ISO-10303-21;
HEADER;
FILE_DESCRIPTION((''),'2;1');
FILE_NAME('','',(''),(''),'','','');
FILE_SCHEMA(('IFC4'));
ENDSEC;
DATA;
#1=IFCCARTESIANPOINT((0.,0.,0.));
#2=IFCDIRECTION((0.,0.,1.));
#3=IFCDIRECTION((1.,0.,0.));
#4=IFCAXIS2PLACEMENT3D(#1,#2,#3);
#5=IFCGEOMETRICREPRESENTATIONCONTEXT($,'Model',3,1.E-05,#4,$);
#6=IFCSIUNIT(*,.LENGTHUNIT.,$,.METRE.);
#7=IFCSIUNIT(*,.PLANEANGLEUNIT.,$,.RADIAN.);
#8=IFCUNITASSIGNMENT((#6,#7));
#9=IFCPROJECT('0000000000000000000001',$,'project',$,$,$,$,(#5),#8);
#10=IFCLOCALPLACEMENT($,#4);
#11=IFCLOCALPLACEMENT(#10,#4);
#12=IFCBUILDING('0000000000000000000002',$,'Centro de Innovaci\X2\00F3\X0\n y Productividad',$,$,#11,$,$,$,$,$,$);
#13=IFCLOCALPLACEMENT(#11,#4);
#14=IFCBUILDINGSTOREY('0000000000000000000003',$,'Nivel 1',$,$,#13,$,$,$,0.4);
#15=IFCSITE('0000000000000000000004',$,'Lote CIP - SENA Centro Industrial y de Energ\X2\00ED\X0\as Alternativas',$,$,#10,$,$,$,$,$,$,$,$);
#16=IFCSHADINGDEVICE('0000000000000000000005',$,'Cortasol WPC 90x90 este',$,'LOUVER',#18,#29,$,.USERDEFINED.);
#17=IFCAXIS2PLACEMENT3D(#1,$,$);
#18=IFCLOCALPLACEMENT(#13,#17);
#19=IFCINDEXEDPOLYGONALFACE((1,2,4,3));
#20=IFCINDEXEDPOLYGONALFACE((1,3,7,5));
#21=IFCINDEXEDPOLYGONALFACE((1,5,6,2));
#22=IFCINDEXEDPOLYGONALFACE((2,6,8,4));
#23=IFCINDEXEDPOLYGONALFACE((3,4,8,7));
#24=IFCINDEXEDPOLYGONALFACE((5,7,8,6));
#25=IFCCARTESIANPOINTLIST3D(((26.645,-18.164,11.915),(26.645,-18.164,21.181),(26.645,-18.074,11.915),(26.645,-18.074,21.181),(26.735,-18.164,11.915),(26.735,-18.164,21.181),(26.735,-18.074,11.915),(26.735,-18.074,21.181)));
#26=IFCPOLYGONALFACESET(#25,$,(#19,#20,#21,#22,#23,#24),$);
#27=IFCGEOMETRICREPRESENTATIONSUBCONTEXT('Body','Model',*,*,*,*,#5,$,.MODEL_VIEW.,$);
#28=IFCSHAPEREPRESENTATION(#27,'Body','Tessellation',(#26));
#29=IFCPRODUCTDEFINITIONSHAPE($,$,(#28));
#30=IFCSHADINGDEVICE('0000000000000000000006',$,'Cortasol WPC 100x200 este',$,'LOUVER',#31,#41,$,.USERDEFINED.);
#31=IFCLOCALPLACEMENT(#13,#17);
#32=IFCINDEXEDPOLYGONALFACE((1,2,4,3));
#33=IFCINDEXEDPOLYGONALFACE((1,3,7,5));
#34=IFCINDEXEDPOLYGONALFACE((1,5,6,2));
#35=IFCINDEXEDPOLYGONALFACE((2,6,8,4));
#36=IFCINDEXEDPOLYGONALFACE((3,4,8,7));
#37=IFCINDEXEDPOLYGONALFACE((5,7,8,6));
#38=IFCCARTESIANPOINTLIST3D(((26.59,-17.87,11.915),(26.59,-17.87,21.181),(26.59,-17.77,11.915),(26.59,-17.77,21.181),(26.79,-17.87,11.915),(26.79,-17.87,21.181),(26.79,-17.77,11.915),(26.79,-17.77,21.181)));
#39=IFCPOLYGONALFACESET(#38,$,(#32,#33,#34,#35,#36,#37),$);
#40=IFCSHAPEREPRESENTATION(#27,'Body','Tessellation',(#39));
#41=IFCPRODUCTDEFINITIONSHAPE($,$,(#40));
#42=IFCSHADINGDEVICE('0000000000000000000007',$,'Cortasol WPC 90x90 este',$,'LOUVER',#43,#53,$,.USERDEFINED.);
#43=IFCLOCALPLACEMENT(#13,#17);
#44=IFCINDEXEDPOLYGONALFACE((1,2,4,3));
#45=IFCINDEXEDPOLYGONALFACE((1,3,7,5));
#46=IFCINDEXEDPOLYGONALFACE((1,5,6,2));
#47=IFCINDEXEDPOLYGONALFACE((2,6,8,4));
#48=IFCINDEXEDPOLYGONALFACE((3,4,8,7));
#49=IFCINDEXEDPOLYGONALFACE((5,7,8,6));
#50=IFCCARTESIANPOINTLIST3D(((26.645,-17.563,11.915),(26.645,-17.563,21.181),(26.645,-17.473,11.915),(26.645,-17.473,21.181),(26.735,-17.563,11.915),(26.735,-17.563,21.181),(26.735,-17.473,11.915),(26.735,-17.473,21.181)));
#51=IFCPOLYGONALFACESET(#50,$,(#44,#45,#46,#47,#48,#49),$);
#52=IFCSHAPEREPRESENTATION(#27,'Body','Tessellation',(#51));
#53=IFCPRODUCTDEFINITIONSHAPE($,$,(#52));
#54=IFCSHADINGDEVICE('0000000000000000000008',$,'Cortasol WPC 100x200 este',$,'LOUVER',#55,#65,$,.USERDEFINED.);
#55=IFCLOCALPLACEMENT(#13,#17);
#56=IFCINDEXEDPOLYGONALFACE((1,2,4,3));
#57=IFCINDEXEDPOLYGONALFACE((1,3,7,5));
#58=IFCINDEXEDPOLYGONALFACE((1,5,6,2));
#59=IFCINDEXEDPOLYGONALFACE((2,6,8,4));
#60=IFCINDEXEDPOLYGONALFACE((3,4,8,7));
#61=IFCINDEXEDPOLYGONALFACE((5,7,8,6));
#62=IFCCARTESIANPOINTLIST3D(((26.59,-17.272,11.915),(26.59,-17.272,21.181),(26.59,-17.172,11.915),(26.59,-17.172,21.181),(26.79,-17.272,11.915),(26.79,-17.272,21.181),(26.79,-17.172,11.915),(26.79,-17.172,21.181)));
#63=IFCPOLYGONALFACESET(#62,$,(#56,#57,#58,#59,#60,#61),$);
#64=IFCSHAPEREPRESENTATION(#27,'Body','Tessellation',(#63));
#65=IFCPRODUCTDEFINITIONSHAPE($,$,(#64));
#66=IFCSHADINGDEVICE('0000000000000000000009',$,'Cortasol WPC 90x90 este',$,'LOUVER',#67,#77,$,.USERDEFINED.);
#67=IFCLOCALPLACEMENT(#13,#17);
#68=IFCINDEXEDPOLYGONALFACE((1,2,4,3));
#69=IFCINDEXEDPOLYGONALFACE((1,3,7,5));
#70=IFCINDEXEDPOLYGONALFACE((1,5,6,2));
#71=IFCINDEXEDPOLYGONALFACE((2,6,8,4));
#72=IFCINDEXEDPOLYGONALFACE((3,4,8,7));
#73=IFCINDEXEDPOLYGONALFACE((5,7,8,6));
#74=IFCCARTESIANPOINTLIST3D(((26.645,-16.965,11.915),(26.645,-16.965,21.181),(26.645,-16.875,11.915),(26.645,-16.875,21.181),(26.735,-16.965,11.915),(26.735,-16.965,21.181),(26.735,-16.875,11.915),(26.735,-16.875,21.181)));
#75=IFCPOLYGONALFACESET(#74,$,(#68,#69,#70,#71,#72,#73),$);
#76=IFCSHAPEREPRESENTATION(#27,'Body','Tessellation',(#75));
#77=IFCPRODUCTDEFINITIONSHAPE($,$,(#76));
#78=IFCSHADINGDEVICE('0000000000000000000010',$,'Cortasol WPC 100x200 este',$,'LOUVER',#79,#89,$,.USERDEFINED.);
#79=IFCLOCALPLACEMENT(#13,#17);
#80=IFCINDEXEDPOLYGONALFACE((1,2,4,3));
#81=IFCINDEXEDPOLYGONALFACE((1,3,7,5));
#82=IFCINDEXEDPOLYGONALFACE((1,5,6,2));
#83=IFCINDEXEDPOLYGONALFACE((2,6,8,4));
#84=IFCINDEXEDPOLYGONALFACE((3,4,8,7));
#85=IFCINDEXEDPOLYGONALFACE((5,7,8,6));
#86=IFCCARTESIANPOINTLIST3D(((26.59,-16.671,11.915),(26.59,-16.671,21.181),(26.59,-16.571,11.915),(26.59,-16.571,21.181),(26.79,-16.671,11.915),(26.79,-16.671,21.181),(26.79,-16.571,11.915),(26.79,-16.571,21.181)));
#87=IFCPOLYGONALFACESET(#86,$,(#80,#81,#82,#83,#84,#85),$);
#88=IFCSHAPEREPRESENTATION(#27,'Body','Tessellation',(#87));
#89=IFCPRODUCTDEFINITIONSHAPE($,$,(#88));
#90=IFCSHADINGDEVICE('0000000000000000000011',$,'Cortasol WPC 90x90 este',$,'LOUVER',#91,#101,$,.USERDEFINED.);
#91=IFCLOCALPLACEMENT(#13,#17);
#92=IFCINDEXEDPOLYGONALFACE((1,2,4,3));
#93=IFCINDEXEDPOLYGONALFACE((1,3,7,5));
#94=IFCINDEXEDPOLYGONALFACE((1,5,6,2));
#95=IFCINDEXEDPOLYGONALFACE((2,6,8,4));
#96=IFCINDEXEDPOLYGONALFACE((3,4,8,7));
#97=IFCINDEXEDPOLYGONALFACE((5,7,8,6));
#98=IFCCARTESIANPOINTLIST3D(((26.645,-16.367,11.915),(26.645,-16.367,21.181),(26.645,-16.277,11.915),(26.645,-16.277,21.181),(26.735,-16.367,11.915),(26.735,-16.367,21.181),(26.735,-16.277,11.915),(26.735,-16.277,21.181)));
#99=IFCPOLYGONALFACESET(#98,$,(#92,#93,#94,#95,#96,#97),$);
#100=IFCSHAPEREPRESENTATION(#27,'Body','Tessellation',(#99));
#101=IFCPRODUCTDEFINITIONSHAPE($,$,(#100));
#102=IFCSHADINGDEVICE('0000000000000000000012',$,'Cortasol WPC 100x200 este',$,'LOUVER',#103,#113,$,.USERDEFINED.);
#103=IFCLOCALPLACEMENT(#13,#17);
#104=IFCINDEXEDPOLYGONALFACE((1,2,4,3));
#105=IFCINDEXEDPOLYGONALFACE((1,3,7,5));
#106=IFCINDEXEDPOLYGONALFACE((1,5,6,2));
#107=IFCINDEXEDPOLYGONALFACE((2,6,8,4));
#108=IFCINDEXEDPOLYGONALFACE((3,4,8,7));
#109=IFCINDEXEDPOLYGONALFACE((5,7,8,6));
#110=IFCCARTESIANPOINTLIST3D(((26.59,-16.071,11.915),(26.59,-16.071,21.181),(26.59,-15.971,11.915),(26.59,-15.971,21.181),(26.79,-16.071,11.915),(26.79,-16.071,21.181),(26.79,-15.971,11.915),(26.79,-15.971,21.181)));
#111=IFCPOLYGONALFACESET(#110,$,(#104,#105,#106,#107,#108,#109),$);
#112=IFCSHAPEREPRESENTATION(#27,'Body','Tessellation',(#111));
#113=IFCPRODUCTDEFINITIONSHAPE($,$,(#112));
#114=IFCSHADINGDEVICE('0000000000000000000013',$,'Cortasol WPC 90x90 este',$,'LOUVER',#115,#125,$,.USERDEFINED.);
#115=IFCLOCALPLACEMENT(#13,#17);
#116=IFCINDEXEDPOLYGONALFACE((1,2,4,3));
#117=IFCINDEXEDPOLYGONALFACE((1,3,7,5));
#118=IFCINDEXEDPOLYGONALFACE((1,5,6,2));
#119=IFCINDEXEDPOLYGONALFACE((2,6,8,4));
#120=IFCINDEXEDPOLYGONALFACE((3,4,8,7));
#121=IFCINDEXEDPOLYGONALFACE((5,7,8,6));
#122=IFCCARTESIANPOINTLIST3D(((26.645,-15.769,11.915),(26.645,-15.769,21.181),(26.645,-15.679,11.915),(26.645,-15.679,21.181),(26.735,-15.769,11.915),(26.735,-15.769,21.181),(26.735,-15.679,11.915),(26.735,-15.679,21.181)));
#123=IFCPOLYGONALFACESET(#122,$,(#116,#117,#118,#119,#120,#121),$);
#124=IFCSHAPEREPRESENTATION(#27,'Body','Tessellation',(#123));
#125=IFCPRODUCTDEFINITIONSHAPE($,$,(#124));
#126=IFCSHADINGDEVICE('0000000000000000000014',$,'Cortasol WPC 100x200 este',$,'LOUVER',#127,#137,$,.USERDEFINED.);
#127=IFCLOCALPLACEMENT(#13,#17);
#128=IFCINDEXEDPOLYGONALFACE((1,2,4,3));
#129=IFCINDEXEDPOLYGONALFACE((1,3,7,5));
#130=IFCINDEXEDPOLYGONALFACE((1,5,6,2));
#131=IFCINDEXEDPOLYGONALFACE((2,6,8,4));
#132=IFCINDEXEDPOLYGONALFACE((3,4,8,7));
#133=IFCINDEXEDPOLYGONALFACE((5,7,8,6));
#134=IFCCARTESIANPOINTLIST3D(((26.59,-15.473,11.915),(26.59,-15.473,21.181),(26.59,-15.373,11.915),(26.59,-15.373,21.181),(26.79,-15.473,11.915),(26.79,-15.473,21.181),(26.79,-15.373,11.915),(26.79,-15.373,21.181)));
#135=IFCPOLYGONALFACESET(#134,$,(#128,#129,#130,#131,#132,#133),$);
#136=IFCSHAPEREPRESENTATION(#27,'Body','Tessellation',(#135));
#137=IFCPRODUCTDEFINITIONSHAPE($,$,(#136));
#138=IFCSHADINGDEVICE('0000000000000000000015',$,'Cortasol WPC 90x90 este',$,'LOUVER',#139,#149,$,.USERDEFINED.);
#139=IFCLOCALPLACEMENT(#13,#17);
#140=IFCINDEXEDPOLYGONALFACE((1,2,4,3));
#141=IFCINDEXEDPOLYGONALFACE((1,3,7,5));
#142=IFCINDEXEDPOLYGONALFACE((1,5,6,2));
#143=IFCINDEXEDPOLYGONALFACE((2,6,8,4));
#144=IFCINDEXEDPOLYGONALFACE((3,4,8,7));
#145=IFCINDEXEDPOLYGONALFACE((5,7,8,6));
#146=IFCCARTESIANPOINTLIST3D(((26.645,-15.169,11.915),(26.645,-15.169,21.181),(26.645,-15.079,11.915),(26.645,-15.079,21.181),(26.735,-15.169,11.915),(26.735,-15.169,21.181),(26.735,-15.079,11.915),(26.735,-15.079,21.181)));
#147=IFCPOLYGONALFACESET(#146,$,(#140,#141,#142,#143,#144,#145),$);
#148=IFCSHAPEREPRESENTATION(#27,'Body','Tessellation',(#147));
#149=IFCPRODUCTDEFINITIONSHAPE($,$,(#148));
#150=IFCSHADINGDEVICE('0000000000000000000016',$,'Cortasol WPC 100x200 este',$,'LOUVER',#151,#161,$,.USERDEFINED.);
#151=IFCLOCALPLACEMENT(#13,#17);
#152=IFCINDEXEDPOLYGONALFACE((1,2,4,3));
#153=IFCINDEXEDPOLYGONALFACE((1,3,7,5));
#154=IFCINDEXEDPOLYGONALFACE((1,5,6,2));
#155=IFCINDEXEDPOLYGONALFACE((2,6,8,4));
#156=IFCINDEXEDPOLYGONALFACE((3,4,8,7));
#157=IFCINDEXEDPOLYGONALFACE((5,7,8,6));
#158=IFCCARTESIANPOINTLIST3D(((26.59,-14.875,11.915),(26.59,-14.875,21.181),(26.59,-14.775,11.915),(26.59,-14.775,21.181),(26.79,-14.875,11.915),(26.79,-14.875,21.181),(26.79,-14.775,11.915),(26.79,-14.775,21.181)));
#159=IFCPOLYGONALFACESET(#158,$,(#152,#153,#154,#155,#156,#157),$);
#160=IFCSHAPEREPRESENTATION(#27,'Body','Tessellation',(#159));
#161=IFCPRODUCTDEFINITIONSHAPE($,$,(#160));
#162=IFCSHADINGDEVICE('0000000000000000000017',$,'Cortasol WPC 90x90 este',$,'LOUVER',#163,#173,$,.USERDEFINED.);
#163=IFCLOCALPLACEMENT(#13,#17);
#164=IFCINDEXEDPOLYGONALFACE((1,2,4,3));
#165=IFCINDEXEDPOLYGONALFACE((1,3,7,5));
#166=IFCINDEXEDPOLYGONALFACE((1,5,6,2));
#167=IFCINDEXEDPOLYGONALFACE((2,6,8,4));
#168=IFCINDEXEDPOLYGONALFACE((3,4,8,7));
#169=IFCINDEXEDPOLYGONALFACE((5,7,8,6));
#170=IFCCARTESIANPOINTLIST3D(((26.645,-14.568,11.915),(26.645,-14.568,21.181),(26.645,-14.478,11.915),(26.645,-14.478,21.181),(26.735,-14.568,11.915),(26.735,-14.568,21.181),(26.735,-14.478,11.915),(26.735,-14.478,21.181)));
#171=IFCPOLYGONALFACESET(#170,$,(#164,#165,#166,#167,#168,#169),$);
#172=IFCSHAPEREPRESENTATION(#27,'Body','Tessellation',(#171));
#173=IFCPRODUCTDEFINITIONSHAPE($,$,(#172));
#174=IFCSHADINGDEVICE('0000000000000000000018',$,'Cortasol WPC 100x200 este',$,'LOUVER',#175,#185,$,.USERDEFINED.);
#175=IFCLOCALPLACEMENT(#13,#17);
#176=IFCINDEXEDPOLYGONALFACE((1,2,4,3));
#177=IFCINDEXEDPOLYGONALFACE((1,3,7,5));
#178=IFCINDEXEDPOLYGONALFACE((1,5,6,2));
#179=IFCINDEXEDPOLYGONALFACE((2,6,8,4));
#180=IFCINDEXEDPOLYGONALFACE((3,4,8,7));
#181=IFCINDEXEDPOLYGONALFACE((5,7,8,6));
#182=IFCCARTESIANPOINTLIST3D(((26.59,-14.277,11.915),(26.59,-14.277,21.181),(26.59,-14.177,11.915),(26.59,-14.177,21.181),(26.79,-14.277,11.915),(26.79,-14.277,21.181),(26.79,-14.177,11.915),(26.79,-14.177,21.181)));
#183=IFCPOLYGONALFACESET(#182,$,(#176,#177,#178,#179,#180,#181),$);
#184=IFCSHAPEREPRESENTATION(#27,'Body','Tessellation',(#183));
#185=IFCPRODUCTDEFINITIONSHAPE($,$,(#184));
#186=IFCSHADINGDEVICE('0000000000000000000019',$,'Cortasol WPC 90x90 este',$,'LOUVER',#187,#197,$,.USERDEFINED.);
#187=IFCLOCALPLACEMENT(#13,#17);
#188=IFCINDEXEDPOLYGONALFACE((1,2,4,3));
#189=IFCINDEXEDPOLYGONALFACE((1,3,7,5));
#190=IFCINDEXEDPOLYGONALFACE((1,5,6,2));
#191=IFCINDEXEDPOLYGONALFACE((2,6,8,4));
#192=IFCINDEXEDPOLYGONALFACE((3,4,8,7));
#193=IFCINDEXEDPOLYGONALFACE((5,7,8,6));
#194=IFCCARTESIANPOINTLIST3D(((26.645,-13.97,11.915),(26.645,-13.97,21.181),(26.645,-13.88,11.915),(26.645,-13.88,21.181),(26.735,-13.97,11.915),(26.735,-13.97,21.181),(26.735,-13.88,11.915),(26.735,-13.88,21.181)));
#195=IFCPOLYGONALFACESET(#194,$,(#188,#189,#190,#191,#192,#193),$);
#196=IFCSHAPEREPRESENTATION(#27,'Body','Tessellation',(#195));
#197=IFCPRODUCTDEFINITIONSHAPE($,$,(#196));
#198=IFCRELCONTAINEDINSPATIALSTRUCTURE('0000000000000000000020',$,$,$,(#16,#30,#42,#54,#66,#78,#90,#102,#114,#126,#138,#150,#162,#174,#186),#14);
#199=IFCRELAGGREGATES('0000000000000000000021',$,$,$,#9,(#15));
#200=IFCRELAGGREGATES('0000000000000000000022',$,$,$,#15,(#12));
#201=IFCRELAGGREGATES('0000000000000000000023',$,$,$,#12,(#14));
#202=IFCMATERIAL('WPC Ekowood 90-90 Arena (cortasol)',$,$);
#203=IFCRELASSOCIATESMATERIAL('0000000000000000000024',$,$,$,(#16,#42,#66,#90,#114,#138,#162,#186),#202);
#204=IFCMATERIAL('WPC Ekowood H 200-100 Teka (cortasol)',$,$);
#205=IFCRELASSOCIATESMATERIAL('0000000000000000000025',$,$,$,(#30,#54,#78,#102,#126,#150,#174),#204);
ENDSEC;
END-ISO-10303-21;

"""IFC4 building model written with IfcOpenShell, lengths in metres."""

from ifc_helpers import new_model, si_unit, frame, origin_with_axes, place, context, subcontext, project, spatial, polyline, outline, extrude, material, element, save


model = new_model("IFC4")

# Units and contexts
model_context = context("Model", 3, precision=1e-05, world=origin_with_axes())
body_context = subcontext(model_context, "Body", "Model", "MODEL_VIEW")
ifc_project = project(units=[si_unit("LENGTHUNIT", "METRE"), si_unit("PLANEANGLEUNIT", "RADIAN")], contexts=[model_context])

# Site, building, storey
site_placement = place(None, origin_with_axes())
site = spatial("IfcSite", under=ifc_project, at=site_placement, Name="Lote CIP - SENA Centro Industrial y de Energías Alternativas")
building_placement = place(site_placement, origin_with_axes())
building = spatial("IfcBuilding", under=site, at=building_placement, Name="Centro de Innovación y Productividad")
storey_placement = place(building_placement, origin_with_axes())
storey = spatial("IfcBuildingStorey", under=building, at=storey_placement, Name="Nivel 1", Elevation=0.4)

# Shading devices
ifc_material_1 = material(Name="WPC Ekowood 90-90 Arena (cortasol)")
shading_device_1_placement = place(storey_placement, origin_with_axes())
element("IfcShadingDevice", 1, at=shading_device_1_placement, inside=storey, material=ifc_material_1, Name="Cortasol WPC 90x90 este", ObjectType="LOUVER", PredefinedType="USERDEFINED", context=body_context, shape_type="SweptSolid", body=[
    extrude(outline(polyline([(26.735, -18.164), (26.645, -18.164), (26.645, -18.074), (26.735, -18.074), (26.735, -18.164)])), frame((0.0, 0.0, 11.915)), (0.0, 0.0, 1.0), 9.266),
])
ifc_material_2 = material(Name="WPC Ekowood H 200-100 Teka (cortasol)")
shading_device_2_placement = place(storey_placement, origin_with_axes())
element("IfcShadingDevice", 2, at=shading_device_2_placement, inside=storey, material=ifc_material_2, Name="Cortasol WPC 100x200 este", ObjectType="LOUVER", PredefinedType="USERDEFINED", context=body_context, shape_type="SweptSolid", body=[
    extrude(outline(polyline([(26.79, -17.87), (26.59, -17.87), (26.59, -17.77), (26.79, -17.77), (26.79, -17.87)])), frame((0.0, 0.0, 11.915)), (0.0, 0.0, 1.0), 9.266),
])
shading_device_3_placement = place(storey_placement, origin_with_axes())
element("IfcShadingDevice", 3, at=shading_device_3_placement, inside=storey, material=ifc_material_1, Name="Cortasol WPC 90x90 este", ObjectType="LOUVER", PredefinedType="USERDEFINED", context=body_context, shape_type="SweptSolid", body=[
    extrude(outline(polyline([(26.735, -17.563), (26.645, -17.563), (26.645, -17.473), (26.735, -17.473), (26.735, -17.563)])), frame((0.0, 0.0, 11.915)), (0.0, 0.0, 1.0), 9.266),
])
shading_device_4_placement = place(storey_placement, origin_with_axes())
element("IfcShadingDevice", 4, at=shading_device_4_placement, inside=storey, material=ifc_material_2, Name="Cortasol WPC 100x200 este", ObjectType="LOUVER", PredefinedType="USERDEFINED", context=body_context, shape_type="SweptSolid", body=[
    extrude(outline(polyline([(26.79, -17.272), (26.59, -17.272), (26.59, -17.172), (26.79, -17.172), (26.79, -17.272)])), frame((0.0, 0.0, 11.915)), (0.0, 0.0, 1.0), 9.266),
])
shading_device_5_placement = place(storey_placement, origin_with_axes())
element("IfcShadingDevice", 5, at=shading_device_5_placement, inside=storey, material=ifc_material_1, Name="Cortasol WPC 90x90 este", ObjectType="LOUVER", PredefinedType="USERDEFINED", context=body_context, shape_type="SweptSolid", body=[
    extrude(outline(polyline([(26.735, -16.965), (26.645, -16.965), (26.645, -16.875), (26.735, -16.875), (26.735, -16.965)])), frame((0.0, 0.0, 11.915)), (0.0, 0.0, 1.0), 9.266),
])
shading_device_6_placement = place(storey_placement, origin_with_axes())
element("IfcShadingDevice", 6, at=shading_device_6_placement, inside=storey, material=ifc_material_2, Name="Cortasol WPC 100x200 este", ObjectType="LOUVER", PredefinedType="USERDEFINED", context=body_context, shape_type="SweptSolid", body=[
    extrude(outline(polyline([(26.79, -16.671), (26.59, -16.671), (26.59, -16.571), (26.79, -16.571), (26.79, -16.671)])), frame((0.0, 0.0, 11.915)), (0.0, 0.0, 1.0), 9.266),
])
shading_device_7_placement = place(storey_placement, origin_with_axes())
element("IfcShadingDevice", 7, at=shading_device_7_placement, inside=storey, material=ifc_material_1, Name="Cortasol WPC 90x90 este", ObjectType="LOUVER", PredefinedType="USERDEFINED", context=body_context, shape_type="SweptSolid", body=[
    extrude(outline(polyline([(26.735, -16.367), (26.645, -16.367), (26.645, -16.277), (26.735, -16.277), (26.735, -16.367)])), frame((0.0, 0.0, 11.915)), (0.0, 0.0, 1.0), 9.266),
])
shading_device_8_placement = place(storey_placement, origin_with_axes())
element("IfcShadingDevice", 8, at=shading_device_8_placement, inside=storey, material=ifc_material_2, Name="Cortasol WPC 100x200 este", ObjectType="LOUVER", PredefinedType="USERDEFINED", context=body_context, shape_type="SweptSolid", body=[
    extrude(outline(polyline([(26.79, -16.071), (26.59, -16.071), (26.59, -15.971), (26.79, -15.971), (26.79, -16.071)])), frame((0.0, 0.0, 11.915)), (0.0, 0.0, 1.0), 9.266),
])
shading_device_9_placement = place(storey_placement, origin_with_axes())
element("IfcShadingDevice", 9, at=shading_device_9_placement, inside=storey, material=ifc_material_1, Name="Cortasol WPC 90x90 este", ObjectType="LOUVER", PredefinedType="USERDEFINED", context=body_context, shape_type="SweptSolid", body=[
    extrude(outline(polyline([(26.735, -15.769), (26.645, -15.769), (26.645, -15.679), (26.735, -15.679), (26.735, -15.769)])), frame((0.0, 0.0, 11.915)), (0.0, 0.0, 1.0), 9.266),
])
shading_device_10_placement = place(storey_placement, origin_with_axes())
element("IfcShadingDevice", 10, at=shading_device_10_placement, inside=storey, material=ifc_material_2, Name="Cortasol WPC 100x200 este", ObjectType="LOUVER", PredefinedType="USERDEFINED", context=body_context, shape_type="SweptSolid", body=[
    extrude(outline(polyline([(26.79, -15.473), (26.59, -15.473), (26.59, -15.373), (26.79, -15.373), (26.79, -15.473)])), frame((0.0, 0.0, 11.915)), (0.0, 0.0, 1.0), 9.266),
])
shading_device_11_placement = place(storey_placement, origin_with_axes())
element("IfcShadingDevice", 11, at=shading_device_11_placement, inside=storey, material=ifc_material_1, Name="Cortasol WPC 90x90 este", ObjectType="LOUVER", PredefinedType="USERDEFINED", context=body_context, shape_type="SweptSolid", body=[
    extrude(outline(polyline([(26.735, -15.169), (26.645, -15.169), (26.645, -15.079), (26.735, -15.079), (26.735, -15.169)])), frame((0.0, 0.0, 11.915)), (0.0, 0.0, 1.0), 9.266),
])
shading_device_12_placement = place(storey_placement, origin_with_axes())
element("IfcShadingDevice", 12, at=shading_device_12_placement, inside=storey, material=ifc_material_2, Name="Cortasol WPC 100x200 este", ObjectType="LOUVER", PredefinedType="USERDEFINED", context=body_context, shape_type="SweptSolid", body=[
    extrude(outline(polyline([(26.79, -14.875), (26.59, -14.875), (26.59, -14.775), (26.79, -14.775), (26.79, -14.875)])), frame((0.0, 0.0, 11.915)), (0.0, 0.0, 1.0), 9.266),
])
shading_device_13_placement = place(storey_placement, origin_with_axes())
element("IfcShadingDevice", 13, at=shading_device_13_placement, inside=storey, material=ifc_material_1, Name="Cortasol WPC 90x90 este", ObjectType="LOUVER", PredefinedType="USERDEFINED", context=body_context, shape_type="SweptSolid", body=[
    extrude(outline(polyline([(26.735, -14.568), (26.645, -14.568), (26.645, -14.478), (26.735, -14.478), (26.735, -14.568)])), frame((0.0, 0.0, 11.915)), (0.0, 0.0, 1.0), 9.266),
])
shading_device_14_placement = place(storey_placement, origin_with_axes())
element("IfcShadingDevice", 14, at=shading_device_14_placement, inside=storey, material=ifc_material_2, Name="Cortasol WPC 100x200 este", ObjectType="LOUVER", PredefinedType="USERDEFINED", context=body_context, shape_type="SweptSolid", body=[
    extrude(outline(polyline([(26.79, -14.277), (26.59, -14.277), (26.59, -14.177), (26.79, -14.177), (26.79, -14.277)])), frame((0.0, 0.0, 11.915)), (0.0, 0.0, 1.0), 9.266),
])
shading_device_15_placement = place(storey_placement, origin_with_axes())
element("IfcShadingDevice", 15, at=shading_device_15_placement, inside=storey, material=ifc_material_1, Name="Cortasol WPC 90x90 este", ObjectType="LOUVER", PredefinedType="USERDEFINED", context=body_context, shape_type="SweptSolid", body=[
    extrude(outline(polyline([(26.735, -13.97), (26.645, -13.97), (26.645, -13.88), (26.735, -13.88), (26.735, -13.97)])), frame((0.0, 0.0, 11.915)), (0.0, 0.0, 1.0), 9.266),
])

save(model, "model.ifc")
